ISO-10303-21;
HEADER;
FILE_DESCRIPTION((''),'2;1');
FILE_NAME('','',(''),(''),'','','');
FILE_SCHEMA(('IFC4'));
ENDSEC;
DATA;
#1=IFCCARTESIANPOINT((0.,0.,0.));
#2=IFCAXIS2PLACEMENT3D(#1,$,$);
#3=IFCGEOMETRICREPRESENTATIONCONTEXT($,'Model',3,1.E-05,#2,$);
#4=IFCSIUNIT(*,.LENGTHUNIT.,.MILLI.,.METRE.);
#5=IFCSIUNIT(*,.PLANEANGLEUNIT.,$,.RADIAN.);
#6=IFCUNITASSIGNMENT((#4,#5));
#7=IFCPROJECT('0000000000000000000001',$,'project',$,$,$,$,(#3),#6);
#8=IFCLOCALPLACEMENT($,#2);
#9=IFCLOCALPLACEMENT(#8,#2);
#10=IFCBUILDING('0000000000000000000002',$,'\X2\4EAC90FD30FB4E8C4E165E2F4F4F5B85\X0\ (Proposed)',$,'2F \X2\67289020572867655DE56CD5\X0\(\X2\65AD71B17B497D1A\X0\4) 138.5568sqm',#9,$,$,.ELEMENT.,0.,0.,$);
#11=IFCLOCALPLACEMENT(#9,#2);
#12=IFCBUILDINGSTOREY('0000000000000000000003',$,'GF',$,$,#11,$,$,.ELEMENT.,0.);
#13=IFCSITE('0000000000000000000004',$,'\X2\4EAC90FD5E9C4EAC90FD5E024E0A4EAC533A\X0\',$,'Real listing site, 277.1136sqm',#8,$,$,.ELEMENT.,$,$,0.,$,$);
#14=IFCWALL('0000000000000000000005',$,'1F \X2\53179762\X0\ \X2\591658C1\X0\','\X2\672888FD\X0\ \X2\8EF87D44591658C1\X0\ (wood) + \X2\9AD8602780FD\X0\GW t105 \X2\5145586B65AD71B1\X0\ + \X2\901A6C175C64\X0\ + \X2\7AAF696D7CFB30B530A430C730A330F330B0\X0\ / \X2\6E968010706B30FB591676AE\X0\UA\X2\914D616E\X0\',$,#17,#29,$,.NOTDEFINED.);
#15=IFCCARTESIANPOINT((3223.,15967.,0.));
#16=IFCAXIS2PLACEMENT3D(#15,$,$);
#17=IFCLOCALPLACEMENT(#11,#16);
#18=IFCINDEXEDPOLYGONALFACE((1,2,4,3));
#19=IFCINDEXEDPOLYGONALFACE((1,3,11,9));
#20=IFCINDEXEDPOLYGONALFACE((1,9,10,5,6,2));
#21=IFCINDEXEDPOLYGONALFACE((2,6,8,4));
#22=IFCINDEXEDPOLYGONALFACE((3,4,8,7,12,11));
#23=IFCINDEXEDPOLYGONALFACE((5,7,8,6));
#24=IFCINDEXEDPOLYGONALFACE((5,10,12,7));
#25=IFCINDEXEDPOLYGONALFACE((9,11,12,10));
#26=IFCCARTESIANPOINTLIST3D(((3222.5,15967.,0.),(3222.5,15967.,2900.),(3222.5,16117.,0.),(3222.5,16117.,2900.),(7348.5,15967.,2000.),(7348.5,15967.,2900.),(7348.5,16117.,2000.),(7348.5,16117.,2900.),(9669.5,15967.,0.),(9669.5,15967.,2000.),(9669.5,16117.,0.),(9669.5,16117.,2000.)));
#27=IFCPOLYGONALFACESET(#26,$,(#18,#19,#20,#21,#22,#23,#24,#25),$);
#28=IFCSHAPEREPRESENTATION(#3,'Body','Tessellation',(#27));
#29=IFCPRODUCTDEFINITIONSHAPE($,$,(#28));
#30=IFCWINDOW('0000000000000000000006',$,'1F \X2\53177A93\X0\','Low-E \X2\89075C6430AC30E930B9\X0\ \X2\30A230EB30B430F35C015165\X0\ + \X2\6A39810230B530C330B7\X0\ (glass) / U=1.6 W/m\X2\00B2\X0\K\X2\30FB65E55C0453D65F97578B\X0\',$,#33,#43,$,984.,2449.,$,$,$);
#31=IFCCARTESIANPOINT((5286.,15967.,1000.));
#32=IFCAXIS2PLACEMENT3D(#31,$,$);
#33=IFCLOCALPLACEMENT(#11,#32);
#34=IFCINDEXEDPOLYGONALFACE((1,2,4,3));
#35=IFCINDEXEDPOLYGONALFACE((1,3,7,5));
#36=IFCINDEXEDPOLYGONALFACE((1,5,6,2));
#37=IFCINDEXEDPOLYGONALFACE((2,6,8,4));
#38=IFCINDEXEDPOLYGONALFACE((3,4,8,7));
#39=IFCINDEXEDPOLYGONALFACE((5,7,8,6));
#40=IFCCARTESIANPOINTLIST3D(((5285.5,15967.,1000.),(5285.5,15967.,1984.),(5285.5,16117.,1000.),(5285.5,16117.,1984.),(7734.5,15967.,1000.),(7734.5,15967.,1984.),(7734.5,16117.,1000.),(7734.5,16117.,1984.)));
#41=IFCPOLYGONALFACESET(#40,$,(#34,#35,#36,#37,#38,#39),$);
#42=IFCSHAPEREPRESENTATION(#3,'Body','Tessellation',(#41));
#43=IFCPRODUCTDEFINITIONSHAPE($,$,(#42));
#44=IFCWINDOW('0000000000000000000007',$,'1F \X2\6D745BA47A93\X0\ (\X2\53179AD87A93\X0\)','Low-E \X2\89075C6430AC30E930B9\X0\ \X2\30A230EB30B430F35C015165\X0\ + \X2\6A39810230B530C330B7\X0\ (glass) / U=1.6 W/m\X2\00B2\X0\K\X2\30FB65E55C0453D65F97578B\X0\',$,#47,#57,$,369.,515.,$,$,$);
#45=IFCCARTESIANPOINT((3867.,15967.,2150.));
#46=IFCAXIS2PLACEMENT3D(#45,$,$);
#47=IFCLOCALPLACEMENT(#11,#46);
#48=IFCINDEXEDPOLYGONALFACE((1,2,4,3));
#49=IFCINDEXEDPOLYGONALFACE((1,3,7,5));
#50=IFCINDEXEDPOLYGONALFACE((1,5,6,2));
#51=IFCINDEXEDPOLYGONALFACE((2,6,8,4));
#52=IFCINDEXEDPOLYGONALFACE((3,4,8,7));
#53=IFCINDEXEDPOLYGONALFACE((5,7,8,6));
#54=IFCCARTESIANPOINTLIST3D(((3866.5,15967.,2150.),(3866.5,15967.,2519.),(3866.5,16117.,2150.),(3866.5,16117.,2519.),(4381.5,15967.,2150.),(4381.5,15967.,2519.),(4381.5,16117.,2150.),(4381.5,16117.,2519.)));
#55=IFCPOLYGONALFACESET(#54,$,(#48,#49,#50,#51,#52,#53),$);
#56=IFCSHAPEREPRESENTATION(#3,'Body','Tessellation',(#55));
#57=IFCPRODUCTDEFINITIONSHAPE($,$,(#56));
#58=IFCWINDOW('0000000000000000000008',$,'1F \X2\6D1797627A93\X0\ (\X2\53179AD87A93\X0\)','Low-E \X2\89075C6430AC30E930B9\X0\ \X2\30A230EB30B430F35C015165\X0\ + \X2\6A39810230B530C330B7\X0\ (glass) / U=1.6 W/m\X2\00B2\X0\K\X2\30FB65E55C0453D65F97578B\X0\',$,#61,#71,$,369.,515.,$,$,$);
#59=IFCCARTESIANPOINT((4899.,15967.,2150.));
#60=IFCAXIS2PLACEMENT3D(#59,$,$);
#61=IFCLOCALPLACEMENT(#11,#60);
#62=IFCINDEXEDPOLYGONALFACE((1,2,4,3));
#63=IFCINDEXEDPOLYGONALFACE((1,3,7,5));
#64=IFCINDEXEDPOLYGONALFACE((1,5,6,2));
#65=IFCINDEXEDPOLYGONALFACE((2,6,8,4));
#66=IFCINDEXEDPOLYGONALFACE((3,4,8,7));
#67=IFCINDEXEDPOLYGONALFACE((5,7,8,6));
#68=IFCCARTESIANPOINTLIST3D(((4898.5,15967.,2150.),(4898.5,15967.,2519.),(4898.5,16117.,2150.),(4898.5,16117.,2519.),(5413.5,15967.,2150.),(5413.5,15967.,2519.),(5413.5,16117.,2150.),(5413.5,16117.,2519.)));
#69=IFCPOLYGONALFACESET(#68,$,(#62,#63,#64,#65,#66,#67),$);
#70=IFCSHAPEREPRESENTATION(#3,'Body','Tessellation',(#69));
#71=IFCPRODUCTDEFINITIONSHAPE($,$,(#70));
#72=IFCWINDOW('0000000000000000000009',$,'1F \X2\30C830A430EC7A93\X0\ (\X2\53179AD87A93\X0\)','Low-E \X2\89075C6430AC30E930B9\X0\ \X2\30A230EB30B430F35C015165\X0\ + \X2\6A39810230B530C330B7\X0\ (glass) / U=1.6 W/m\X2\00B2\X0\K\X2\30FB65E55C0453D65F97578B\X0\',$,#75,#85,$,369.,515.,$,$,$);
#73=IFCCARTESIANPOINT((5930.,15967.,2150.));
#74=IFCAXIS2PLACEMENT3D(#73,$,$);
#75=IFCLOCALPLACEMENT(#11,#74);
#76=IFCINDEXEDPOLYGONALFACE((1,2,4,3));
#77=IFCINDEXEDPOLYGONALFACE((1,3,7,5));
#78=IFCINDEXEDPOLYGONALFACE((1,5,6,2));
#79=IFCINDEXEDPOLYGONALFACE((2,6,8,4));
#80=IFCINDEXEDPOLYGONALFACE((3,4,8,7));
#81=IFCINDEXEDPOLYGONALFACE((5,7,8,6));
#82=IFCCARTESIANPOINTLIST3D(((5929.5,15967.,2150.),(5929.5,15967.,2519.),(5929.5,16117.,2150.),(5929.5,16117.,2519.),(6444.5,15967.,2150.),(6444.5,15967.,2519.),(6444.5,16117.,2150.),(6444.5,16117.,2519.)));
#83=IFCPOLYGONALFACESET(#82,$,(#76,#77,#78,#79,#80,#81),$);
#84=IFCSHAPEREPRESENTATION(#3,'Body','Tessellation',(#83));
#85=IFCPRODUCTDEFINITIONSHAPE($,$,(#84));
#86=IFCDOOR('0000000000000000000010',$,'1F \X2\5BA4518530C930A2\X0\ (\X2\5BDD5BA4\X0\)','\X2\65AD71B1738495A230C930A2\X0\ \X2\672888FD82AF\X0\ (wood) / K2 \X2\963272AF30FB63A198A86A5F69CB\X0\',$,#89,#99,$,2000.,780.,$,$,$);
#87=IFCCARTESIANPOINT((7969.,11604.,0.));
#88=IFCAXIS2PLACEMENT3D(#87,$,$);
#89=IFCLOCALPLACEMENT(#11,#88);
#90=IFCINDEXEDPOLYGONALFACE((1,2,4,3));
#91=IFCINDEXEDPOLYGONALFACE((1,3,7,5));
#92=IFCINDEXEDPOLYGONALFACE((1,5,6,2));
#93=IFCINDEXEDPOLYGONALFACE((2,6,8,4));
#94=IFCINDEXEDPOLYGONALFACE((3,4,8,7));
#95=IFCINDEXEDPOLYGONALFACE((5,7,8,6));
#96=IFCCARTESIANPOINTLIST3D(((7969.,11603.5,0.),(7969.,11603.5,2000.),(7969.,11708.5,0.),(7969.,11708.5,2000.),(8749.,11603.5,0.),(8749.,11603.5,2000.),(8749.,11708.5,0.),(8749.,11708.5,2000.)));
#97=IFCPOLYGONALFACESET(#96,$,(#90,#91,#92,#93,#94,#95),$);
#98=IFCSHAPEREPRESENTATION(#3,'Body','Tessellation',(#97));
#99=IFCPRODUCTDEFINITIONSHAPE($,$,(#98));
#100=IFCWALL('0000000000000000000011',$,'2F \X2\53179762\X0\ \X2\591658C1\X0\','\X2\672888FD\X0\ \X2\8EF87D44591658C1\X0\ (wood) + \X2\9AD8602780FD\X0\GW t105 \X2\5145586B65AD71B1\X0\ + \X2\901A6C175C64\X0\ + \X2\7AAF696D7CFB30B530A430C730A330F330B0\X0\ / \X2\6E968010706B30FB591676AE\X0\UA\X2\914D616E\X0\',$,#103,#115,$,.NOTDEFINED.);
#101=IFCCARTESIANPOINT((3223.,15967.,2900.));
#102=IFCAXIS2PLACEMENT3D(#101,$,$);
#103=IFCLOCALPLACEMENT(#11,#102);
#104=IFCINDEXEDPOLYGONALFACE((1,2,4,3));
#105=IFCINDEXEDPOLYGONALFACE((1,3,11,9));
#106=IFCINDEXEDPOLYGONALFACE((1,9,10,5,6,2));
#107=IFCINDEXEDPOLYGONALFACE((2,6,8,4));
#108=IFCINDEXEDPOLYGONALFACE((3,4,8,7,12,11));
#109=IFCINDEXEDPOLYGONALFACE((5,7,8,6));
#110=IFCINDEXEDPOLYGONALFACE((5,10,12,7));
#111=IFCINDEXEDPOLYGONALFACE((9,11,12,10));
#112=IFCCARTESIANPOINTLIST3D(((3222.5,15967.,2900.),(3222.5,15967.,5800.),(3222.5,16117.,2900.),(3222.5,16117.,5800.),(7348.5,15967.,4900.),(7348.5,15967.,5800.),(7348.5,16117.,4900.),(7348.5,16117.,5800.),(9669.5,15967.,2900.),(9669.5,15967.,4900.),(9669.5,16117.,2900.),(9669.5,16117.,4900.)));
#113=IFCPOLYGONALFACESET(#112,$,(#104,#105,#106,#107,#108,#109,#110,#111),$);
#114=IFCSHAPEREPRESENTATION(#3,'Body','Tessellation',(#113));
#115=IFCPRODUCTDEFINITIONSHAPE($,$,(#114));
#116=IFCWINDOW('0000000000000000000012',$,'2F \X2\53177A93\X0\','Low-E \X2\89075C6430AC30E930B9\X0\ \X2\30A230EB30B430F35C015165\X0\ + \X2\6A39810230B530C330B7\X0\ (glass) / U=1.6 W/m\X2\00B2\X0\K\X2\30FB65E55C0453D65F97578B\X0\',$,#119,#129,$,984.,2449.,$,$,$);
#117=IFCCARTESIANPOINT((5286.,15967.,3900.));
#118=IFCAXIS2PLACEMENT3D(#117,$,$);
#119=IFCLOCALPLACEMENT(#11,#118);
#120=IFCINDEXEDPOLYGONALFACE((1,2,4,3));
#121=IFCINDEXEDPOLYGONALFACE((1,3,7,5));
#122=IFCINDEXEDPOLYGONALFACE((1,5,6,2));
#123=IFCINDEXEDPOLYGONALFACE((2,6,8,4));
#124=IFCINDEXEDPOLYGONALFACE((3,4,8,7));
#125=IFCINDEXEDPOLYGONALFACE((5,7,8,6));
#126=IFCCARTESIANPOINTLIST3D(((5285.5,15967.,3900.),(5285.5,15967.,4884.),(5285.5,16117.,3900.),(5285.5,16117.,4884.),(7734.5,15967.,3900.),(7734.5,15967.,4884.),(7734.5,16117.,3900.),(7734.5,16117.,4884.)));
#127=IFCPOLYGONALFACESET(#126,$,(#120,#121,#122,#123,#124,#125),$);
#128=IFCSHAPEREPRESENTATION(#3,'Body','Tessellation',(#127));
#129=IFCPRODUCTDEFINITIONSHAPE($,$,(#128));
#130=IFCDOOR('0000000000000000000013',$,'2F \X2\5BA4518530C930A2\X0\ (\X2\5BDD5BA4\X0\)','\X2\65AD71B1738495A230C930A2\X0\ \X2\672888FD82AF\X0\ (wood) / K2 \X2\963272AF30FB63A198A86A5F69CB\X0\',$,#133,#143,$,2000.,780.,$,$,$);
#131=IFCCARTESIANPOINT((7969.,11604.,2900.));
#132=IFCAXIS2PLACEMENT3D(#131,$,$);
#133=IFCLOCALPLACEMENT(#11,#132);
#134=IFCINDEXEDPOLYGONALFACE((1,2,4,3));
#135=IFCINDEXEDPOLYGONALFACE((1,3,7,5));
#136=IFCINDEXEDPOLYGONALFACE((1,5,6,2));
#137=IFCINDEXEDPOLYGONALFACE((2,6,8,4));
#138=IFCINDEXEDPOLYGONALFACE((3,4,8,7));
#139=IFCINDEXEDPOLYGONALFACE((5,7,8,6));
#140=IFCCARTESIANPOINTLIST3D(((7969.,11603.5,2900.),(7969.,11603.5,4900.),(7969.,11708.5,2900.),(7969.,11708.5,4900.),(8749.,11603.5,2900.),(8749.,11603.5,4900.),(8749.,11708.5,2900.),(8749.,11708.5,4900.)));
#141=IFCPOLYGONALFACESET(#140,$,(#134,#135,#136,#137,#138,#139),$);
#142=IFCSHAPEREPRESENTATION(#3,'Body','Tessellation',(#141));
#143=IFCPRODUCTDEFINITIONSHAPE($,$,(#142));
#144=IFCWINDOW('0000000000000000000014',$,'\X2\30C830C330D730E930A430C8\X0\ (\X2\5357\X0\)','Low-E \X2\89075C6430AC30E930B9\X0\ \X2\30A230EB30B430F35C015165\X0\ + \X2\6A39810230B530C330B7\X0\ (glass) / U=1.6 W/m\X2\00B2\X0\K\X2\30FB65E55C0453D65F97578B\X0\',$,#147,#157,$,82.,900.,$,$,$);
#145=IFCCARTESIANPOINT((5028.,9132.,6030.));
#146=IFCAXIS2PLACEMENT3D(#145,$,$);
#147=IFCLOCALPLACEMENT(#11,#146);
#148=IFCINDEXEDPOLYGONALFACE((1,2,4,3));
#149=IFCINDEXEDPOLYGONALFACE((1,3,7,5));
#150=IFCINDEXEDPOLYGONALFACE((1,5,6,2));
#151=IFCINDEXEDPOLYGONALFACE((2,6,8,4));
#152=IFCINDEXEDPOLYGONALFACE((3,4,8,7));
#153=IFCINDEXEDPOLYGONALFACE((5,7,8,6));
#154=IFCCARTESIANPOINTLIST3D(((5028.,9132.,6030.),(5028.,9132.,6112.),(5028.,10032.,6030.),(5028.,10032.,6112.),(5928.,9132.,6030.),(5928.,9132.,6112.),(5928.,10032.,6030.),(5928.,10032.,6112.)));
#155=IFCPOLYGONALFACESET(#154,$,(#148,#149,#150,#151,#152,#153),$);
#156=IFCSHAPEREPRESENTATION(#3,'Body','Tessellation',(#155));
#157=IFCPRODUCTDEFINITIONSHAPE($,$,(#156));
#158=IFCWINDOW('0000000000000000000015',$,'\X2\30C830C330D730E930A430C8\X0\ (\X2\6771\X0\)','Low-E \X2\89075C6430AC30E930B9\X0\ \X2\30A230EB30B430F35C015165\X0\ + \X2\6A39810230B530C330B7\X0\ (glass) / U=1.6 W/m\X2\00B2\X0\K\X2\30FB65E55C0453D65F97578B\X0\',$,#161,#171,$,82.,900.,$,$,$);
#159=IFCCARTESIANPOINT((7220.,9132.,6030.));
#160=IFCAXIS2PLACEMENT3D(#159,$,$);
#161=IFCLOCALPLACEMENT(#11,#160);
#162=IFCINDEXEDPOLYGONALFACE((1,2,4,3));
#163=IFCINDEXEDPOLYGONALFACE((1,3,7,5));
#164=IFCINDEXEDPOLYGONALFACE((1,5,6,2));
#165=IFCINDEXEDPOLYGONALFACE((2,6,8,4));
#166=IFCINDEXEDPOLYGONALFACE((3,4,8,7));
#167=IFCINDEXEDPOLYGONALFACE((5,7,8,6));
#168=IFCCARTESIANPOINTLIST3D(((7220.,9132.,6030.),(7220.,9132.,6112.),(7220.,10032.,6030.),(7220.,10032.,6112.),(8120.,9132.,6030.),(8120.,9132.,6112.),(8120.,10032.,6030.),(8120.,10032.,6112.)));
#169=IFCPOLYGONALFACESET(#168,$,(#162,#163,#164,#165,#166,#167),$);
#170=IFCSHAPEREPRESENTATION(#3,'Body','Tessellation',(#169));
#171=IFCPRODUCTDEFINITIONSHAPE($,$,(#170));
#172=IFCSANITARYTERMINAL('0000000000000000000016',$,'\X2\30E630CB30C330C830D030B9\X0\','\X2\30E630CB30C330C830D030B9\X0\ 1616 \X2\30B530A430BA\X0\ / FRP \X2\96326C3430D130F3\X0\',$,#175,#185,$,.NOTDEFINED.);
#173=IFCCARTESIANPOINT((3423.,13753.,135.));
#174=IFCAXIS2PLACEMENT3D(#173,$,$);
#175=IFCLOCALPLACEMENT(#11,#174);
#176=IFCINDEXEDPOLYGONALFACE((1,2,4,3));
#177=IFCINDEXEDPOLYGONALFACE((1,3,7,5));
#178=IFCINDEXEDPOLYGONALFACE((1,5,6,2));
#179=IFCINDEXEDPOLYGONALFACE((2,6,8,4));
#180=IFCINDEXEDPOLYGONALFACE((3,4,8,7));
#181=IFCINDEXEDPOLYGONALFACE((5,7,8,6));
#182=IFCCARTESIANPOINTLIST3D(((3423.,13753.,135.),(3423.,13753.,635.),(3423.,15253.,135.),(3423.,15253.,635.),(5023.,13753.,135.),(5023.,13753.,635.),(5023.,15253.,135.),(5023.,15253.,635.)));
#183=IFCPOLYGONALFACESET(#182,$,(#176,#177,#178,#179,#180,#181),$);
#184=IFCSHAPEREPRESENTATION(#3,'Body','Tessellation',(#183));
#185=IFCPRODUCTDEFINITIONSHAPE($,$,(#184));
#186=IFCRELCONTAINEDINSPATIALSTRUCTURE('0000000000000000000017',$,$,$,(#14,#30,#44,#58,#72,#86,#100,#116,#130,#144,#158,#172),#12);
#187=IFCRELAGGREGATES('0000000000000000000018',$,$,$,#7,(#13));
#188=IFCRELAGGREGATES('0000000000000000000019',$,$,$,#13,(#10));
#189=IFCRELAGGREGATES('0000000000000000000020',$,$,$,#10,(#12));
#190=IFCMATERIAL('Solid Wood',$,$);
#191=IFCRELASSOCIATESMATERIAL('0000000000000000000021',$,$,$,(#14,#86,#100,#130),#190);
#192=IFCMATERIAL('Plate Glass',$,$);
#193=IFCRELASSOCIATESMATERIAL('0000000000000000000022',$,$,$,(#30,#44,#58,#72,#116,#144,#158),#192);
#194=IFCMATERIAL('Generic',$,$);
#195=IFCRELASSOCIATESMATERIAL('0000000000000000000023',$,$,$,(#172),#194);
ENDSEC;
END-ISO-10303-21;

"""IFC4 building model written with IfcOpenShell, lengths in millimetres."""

from ifc_helpers import new_model, si_unit, frame, frame_2d, origin, place, context, project, spatial, rectangle, extrude, material, element, fill, save


model = new_model("IFC4")

# Units and contexts
model_context = context("Model", 3, precision=1e-05, world=origin())
ifc_project = project(units=[si_unit("LENGTHUNIT", "METRE", prefix="MILLI"), si_unit("PLANEANGLEUNIT", "RADIAN")], contexts=[model_context])

# Site, building, storey
site_placement = place(None, origin())
site = spatial("IfcSite", under=ifc_project, at=site_placement, Name="京都府京都市上京区", ObjectType="Real listing site, 277.1136sqm", CompositionType="ELEMENT", RefElevation=0.0)
building_placement = place(site_placement, origin())
building = spatial("IfcBuilding", under=site, at=building_placement, Name="京都・二世帯住宅 (Proposed)", ObjectType="2F 木造在来工法(断熱等級4) 138.5568sqm", CompositionType="ELEMENT", ElevationOfRefHeight=0.0, ElevationOfTerrain=0.0)
storey_placement = place(building_placement, origin())
storey = spatial("IfcBuildingStorey", under=building, at=storey_placement, Name="GF", CompositionType="ELEMENT", Elevation=0.0)

# Wall, openings, windows
ifc_material_1 = material(Name="Solid Wood")
wall_1_placement = place(storey_placement, frame((3223.0, 15967.0, 0.0)))
wall_1 = element("IfcWall", 1, at=wall_1_placement, inside=storey, material=ifc_material_1, Name="1F 北面 外壁", Description="木製 軸組外壁 (wood) + 高性能GW t105 充填断熱 + 通気層 + 窯業系サイディング / 準耐火・外皮UA配慮", PredefinedType="NOTDEFINED", context=model_context, shape_type="SweptSolid", body=[
    extrude(rectangle(XDim=6447.0, YDim=150.0, at=frame_2d((3223.0, 75.0))), frame((3223.0, 15967.0, 0.0)), (0.0, 0.0, 1.0), 2900.0),
])
opening_1_placement = place(storey_placement, frame((5286.0, 15967.0, 1000.0)))
opening_1 = element("IfcOpeningElement", 2, at=opening_1_placement, cuts=wall_1, PredefinedType="NOTDEFINED", context=model_context, shape_type="SweptSolid", body=[
    extrude(rectangle(XDim=2449.0, YDim=150.0, at=frame_2d((1224.0, 75.0))), frame((5286.0, 15967.0, 1000.0)), (0.0, 0.0, 1.0), 984.0),
])
opening_2_placement = place(storey_placement, frame((3867.0, 15967.0, 2150.0)))
opening_2 = element("IfcOpeningElement", 3, at=opening_2_placement, cuts=wall_1, PredefinedType="NOTDEFINED", context=model_context, shape_type="SweptSolid", body=[
    extrude(rectangle(XDim=515.0, YDim=150.0, at=frame_2d((257.0, 75.0))), frame((3867.0, 15967.0, 2150.0)), (0.0, 0.0, 1.0), 369.0),
])
opening_3_placement = place(storey_placement, frame((4899.0, 15967.0, 2150.0)))
opening_3 = element("IfcOpeningElement", 4, at=opening_3_placement, cuts=wall_1, PredefinedType="NOTDEFINED", context=model_context, shape_type="SweptSolid", body=[
    extrude(rectangle(XDim=515.0, YDim=150.0, at=frame_2d((257.0, 75.0))), frame((4899.0, 15967.0, 2150.0)), (0.0, 0.0, 1.0), 369.0),
])
opening_4_placement = place(storey_placement, frame((5930.0, 15967.0, 2150.0)))
opening_4 = element("IfcOpeningElement", 5, at=opening_4_placement, cuts=wall_1, PredefinedType="NOTDEFINED", context=model_context, shape_type="SweptSolid", body=[
    extrude(rectangle(XDim=515.0, YDim=150.0, at=frame_2d((257.0, 75.0))), frame((5930.0, 15967.0, 2150.0)), (0.0, 0.0, 1.0), 369.0),
])
ifc_material_2 = material(Name="Plate Glass")
window_1_placement = place(storey_placement, frame((5286.0, 15967.0, 1000.0)))
window_1 = element("IfcWindow", 6, at=window_1_placement, inside=storey, material=ifc_material_2, Name="1F 北窓", Description="Low-E 複層ガラス アルゴン封入 + 樹脂サッシ (glass) / U=1.6 W/m²K・日射取得型", OverallHeight=984.0, OverallWidth=2449.0, context=model_context, shape_type="SweptSolid", body=[
    extrude(rectangle(XDim=2449.0, YDim=150.0, at=frame_2d((1224.0, 75.0))), frame((5286.0, 15967.0, 1000.0)), (0.0, 0.0, 1.0), 984.0),
])
fill(opening_1, window_1)
window_2_placement = place(storey_placement, frame((3867.0, 15967.0, 2150.0)))
window_2 = element("IfcWindow", 7, at=window_2_placement, inside=storey, material=ifc_material_2, Name="1F 浴室窓 (北高窓)", Description="Low-E 複層ガラス アルゴン封入 + 樹脂サッシ (glass) / U=1.6 W/m²K・日射取得型", OverallHeight=369.0, OverallWidth=515.0, context=model_context, shape_type="SweptSolid", body=[
    extrude(rectangle(XDim=515.0, YDim=150.0, at=frame_2d((257.0, 75.0))), frame((3867.0, 15967.0, 2150.0)), (0.0, 0.0, 1.0), 369.0),
])
fill(opening_2, window_2)
window_3_placement = place(storey_placement, frame((4899.0, 15967.0, 2150.0)))
window_3 = element("IfcWindow", 8, at=window_3_placement, inside=storey, material=ifc_material_2, Name="1F 洗面窓 (北高窓)", Description="Low-E 複層ガラス アルゴン封入 + 樹脂サッシ (glass) / U=1.6 W/m²K・日射取得型", OverallHeight=369.0, OverallWidth=515.0, context=model_context, shape_type="SweptSolid", body=[
    extrude(rectangle(XDim=515.0, YDim=150.0, at=frame_2d((257.0, 75.0))), frame((4899.0, 15967.0, 2150.0)), (0.0, 0.0, 1.0), 369.0),
])
fill(opening_3, window_3)
window_4_placement = place(storey_placement, frame((5930.0, 15967.0, 2150.0)))
window_4 = element("IfcWindow", 9, at=window_4_placement, inside=storey, material=ifc_material_2, Name="1F トイレ窓 (北高窓)", Description="Low-E 複層ガラス アルゴン封入 + 樹脂サッシ (glass) / U=1.6 W/m²K・日射取得型", OverallHeight=369.0, OverallWidth=515.0, context=model_context, shape_type="SweptSolid", body=[
    extrude(rectangle(XDim=515.0, YDim=150.0, at=frame_2d((257.0, 75.0))), frame((5930.0, 15967.0, 2150.0)), (0.0, 0.0, 1.0), 369.0),
])
fill(opening_4, window_4)

# Door
door_1_placement = place(storey_placement, frame((7969.0, 11604.0, 0.0)))
element("IfcDoor", 10, at=door_1_placement, inside=storey, material=ifc_material_1, Name="1F 室内ドア (寝室)", Description="断熱玄関ドア 木製芯 (wood) / K2 防犯・採風機構", OverallHeight=2000.0, OverallWidth=780.0, context=model_context, shape_type="SweptSolid", body=[
    extrude(rectangle(XDim=780.0, YDim=105.0, at=frame_2d((390.0, 52.0))), frame((7969.0, 11604.0, 0.0)), (0.0, 0.0, 1.0), 2000.0),
])

# Wall, opening, window
wall_2_placement = place(storey_placement, frame((3223.0, 15967.0, 2900.0)))
wall_2 = element("IfcWall", 11, at=wall_2_placement, inside=storey, material=ifc_material_1, Name="2F 北面 外壁", Description="木製 軸組外壁 (wood) + 高性能GW t105 充填断熱 + 通気層 + 窯業系サイディング / 準耐火・外皮UA配慮", PredefinedType="NOTDEFINED", context=model_context, shape_type="SweptSolid", body=[
    extrude(rectangle(XDim=6447.0, YDim=150.0, at=frame_2d((3223.0, 75.0))), frame((3223.0, 15967.0, 2900.0)), (0.0, 0.0, 1.0), 2900.0),
])
opening_5_placement = place(storey_placement, frame((5286.0, 15967.0, 3900.0)))
opening_5 = element("IfcOpeningElement", 12, at=opening_5_placement, cuts=wall_2, PredefinedType="NOTDEFINED", context=model_context, shape_type="SweptSolid", body=[
    extrude(rectangle(XDim=2449.0, YDim=150.0, at=frame_2d((1224.0, 75.0))), frame((5286.0, 15967.0, 3900.0)), (0.0, 0.0, 1.0), 984.0),
])
window_5_placement = place(storey_placement, frame((5286.0, 15967.0, 3900.0)))
window_5 = element("IfcWindow", 13, at=window_5_placement, inside=storey, material=ifc_material_2, Name="2F 北窓", Description="Low-E 複層ガラス アルゴン封入 + 樹脂サッシ (glass) / U=1.6 W/m²K・日射取得型", OverallHeight=984.0, OverallWidth=2449.0, context=model_context, shape_type="SweptSolid", body=[
    extrude(rectangle(XDim=2449.0, YDim=150.0, at=frame_2d((1224.0, 75.0))), frame((5286.0, 15967.0, 3900.0)), (0.0, 0.0, 1.0), 984.0),
])
fill(opening_5, window_5)

# Door
door_2_placement = place(storey_placement, frame((7969.0, 11604.0, 2900.0)))
element("IfcDoor", 14, at=door_2_placement, inside=storey, material=ifc_material_1, Name="2F 室内ドア (寝室)", Description="断熱玄関ドア 木製芯 (wood) / K2 防犯・採風機構", OverallHeight=2000.0, OverallWidth=780.0, context=model_context, shape_type="SweptSolid", body=[
    extrude(rectangle(XDim=780.0, YDim=105.0, at=frame_2d((390.0, 52.0))), frame((7969.0, 11604.0, 2900.0)), (0.0, 0.0, 1.0), 2000.0),
])

# Windows
window_6_placement = place(storey_placement, frame((5028.0, 9132.0, 6030.0)))
element("IfcWindow", 15, at=window_6_placement, inside=storey, material=ifc_material_2, Name="トップライト (南)", Description="Low-E 複層ガラス アルゴン封入 + 樹脂サッシ (glass) / U=1.6 W/m²K・日射取得型", OverallHeight=82.0, OverallWidth=900.0, context=model_context, shape_type="SweptSolid", body=[
    extrude(rectangle(XDim=900.0, YDim=900.0, at=frame_2d((450.0, 450.0))), frame((5028.0, 9132.0, 6030.0)), (0.0, 0.0, 1.0), 82.0),
])
window_7_placement = place(storey_placement, frame((7220.0, 9132.0, 6030.0)))
element("IfcWindow", 16, at=window_7_placement, inside=storey, material=ifc_material_2, Name="トップライト (東)", Description="Low-E 複層ガラス アルゴン封入 + 樹脂サッシ (glass) / U=1.6 W/m²K・日射取得型", OverallHeight=82.0, OverallWidth=900.0, context=model_context, shape_type="SweptSolid", body=[
    extrude(rectangle(XDim=900.0, YDim=900.0, at=frame_2d((450.0, 450.0))), frame((7220.0, 9132.0, 6030.0)), (0.0, 0.0, 1.0), 82.0),
])

# Sanitary terminal
ifc_material_3 = material(Name="Generic")
sanitary_terminal_1_placement = place(storey_placement, frame((3423.0, 13753.0, 135.0)))
element("IfcSanitaryTerminal", 17, at=sanitary_terminal_1_placement, inside=storey, material=ifc_material_3, Name="ユニットバス", Description="ユニットバス 1616 サイズ / FRP 防水パン", PredefinedType="NOTDEFINED", context=model_context, shape_type="SweptSolid", body=[
    extrude(rectangle(XDim=1600.0, YDim=1500.0, at=frame_2d((800.0, 750.0))), frame((3423.0, 13753.0, 135.0)), (0.0, 0.0, 1.0), 500.0),
])

save(model, "model.ifc")
